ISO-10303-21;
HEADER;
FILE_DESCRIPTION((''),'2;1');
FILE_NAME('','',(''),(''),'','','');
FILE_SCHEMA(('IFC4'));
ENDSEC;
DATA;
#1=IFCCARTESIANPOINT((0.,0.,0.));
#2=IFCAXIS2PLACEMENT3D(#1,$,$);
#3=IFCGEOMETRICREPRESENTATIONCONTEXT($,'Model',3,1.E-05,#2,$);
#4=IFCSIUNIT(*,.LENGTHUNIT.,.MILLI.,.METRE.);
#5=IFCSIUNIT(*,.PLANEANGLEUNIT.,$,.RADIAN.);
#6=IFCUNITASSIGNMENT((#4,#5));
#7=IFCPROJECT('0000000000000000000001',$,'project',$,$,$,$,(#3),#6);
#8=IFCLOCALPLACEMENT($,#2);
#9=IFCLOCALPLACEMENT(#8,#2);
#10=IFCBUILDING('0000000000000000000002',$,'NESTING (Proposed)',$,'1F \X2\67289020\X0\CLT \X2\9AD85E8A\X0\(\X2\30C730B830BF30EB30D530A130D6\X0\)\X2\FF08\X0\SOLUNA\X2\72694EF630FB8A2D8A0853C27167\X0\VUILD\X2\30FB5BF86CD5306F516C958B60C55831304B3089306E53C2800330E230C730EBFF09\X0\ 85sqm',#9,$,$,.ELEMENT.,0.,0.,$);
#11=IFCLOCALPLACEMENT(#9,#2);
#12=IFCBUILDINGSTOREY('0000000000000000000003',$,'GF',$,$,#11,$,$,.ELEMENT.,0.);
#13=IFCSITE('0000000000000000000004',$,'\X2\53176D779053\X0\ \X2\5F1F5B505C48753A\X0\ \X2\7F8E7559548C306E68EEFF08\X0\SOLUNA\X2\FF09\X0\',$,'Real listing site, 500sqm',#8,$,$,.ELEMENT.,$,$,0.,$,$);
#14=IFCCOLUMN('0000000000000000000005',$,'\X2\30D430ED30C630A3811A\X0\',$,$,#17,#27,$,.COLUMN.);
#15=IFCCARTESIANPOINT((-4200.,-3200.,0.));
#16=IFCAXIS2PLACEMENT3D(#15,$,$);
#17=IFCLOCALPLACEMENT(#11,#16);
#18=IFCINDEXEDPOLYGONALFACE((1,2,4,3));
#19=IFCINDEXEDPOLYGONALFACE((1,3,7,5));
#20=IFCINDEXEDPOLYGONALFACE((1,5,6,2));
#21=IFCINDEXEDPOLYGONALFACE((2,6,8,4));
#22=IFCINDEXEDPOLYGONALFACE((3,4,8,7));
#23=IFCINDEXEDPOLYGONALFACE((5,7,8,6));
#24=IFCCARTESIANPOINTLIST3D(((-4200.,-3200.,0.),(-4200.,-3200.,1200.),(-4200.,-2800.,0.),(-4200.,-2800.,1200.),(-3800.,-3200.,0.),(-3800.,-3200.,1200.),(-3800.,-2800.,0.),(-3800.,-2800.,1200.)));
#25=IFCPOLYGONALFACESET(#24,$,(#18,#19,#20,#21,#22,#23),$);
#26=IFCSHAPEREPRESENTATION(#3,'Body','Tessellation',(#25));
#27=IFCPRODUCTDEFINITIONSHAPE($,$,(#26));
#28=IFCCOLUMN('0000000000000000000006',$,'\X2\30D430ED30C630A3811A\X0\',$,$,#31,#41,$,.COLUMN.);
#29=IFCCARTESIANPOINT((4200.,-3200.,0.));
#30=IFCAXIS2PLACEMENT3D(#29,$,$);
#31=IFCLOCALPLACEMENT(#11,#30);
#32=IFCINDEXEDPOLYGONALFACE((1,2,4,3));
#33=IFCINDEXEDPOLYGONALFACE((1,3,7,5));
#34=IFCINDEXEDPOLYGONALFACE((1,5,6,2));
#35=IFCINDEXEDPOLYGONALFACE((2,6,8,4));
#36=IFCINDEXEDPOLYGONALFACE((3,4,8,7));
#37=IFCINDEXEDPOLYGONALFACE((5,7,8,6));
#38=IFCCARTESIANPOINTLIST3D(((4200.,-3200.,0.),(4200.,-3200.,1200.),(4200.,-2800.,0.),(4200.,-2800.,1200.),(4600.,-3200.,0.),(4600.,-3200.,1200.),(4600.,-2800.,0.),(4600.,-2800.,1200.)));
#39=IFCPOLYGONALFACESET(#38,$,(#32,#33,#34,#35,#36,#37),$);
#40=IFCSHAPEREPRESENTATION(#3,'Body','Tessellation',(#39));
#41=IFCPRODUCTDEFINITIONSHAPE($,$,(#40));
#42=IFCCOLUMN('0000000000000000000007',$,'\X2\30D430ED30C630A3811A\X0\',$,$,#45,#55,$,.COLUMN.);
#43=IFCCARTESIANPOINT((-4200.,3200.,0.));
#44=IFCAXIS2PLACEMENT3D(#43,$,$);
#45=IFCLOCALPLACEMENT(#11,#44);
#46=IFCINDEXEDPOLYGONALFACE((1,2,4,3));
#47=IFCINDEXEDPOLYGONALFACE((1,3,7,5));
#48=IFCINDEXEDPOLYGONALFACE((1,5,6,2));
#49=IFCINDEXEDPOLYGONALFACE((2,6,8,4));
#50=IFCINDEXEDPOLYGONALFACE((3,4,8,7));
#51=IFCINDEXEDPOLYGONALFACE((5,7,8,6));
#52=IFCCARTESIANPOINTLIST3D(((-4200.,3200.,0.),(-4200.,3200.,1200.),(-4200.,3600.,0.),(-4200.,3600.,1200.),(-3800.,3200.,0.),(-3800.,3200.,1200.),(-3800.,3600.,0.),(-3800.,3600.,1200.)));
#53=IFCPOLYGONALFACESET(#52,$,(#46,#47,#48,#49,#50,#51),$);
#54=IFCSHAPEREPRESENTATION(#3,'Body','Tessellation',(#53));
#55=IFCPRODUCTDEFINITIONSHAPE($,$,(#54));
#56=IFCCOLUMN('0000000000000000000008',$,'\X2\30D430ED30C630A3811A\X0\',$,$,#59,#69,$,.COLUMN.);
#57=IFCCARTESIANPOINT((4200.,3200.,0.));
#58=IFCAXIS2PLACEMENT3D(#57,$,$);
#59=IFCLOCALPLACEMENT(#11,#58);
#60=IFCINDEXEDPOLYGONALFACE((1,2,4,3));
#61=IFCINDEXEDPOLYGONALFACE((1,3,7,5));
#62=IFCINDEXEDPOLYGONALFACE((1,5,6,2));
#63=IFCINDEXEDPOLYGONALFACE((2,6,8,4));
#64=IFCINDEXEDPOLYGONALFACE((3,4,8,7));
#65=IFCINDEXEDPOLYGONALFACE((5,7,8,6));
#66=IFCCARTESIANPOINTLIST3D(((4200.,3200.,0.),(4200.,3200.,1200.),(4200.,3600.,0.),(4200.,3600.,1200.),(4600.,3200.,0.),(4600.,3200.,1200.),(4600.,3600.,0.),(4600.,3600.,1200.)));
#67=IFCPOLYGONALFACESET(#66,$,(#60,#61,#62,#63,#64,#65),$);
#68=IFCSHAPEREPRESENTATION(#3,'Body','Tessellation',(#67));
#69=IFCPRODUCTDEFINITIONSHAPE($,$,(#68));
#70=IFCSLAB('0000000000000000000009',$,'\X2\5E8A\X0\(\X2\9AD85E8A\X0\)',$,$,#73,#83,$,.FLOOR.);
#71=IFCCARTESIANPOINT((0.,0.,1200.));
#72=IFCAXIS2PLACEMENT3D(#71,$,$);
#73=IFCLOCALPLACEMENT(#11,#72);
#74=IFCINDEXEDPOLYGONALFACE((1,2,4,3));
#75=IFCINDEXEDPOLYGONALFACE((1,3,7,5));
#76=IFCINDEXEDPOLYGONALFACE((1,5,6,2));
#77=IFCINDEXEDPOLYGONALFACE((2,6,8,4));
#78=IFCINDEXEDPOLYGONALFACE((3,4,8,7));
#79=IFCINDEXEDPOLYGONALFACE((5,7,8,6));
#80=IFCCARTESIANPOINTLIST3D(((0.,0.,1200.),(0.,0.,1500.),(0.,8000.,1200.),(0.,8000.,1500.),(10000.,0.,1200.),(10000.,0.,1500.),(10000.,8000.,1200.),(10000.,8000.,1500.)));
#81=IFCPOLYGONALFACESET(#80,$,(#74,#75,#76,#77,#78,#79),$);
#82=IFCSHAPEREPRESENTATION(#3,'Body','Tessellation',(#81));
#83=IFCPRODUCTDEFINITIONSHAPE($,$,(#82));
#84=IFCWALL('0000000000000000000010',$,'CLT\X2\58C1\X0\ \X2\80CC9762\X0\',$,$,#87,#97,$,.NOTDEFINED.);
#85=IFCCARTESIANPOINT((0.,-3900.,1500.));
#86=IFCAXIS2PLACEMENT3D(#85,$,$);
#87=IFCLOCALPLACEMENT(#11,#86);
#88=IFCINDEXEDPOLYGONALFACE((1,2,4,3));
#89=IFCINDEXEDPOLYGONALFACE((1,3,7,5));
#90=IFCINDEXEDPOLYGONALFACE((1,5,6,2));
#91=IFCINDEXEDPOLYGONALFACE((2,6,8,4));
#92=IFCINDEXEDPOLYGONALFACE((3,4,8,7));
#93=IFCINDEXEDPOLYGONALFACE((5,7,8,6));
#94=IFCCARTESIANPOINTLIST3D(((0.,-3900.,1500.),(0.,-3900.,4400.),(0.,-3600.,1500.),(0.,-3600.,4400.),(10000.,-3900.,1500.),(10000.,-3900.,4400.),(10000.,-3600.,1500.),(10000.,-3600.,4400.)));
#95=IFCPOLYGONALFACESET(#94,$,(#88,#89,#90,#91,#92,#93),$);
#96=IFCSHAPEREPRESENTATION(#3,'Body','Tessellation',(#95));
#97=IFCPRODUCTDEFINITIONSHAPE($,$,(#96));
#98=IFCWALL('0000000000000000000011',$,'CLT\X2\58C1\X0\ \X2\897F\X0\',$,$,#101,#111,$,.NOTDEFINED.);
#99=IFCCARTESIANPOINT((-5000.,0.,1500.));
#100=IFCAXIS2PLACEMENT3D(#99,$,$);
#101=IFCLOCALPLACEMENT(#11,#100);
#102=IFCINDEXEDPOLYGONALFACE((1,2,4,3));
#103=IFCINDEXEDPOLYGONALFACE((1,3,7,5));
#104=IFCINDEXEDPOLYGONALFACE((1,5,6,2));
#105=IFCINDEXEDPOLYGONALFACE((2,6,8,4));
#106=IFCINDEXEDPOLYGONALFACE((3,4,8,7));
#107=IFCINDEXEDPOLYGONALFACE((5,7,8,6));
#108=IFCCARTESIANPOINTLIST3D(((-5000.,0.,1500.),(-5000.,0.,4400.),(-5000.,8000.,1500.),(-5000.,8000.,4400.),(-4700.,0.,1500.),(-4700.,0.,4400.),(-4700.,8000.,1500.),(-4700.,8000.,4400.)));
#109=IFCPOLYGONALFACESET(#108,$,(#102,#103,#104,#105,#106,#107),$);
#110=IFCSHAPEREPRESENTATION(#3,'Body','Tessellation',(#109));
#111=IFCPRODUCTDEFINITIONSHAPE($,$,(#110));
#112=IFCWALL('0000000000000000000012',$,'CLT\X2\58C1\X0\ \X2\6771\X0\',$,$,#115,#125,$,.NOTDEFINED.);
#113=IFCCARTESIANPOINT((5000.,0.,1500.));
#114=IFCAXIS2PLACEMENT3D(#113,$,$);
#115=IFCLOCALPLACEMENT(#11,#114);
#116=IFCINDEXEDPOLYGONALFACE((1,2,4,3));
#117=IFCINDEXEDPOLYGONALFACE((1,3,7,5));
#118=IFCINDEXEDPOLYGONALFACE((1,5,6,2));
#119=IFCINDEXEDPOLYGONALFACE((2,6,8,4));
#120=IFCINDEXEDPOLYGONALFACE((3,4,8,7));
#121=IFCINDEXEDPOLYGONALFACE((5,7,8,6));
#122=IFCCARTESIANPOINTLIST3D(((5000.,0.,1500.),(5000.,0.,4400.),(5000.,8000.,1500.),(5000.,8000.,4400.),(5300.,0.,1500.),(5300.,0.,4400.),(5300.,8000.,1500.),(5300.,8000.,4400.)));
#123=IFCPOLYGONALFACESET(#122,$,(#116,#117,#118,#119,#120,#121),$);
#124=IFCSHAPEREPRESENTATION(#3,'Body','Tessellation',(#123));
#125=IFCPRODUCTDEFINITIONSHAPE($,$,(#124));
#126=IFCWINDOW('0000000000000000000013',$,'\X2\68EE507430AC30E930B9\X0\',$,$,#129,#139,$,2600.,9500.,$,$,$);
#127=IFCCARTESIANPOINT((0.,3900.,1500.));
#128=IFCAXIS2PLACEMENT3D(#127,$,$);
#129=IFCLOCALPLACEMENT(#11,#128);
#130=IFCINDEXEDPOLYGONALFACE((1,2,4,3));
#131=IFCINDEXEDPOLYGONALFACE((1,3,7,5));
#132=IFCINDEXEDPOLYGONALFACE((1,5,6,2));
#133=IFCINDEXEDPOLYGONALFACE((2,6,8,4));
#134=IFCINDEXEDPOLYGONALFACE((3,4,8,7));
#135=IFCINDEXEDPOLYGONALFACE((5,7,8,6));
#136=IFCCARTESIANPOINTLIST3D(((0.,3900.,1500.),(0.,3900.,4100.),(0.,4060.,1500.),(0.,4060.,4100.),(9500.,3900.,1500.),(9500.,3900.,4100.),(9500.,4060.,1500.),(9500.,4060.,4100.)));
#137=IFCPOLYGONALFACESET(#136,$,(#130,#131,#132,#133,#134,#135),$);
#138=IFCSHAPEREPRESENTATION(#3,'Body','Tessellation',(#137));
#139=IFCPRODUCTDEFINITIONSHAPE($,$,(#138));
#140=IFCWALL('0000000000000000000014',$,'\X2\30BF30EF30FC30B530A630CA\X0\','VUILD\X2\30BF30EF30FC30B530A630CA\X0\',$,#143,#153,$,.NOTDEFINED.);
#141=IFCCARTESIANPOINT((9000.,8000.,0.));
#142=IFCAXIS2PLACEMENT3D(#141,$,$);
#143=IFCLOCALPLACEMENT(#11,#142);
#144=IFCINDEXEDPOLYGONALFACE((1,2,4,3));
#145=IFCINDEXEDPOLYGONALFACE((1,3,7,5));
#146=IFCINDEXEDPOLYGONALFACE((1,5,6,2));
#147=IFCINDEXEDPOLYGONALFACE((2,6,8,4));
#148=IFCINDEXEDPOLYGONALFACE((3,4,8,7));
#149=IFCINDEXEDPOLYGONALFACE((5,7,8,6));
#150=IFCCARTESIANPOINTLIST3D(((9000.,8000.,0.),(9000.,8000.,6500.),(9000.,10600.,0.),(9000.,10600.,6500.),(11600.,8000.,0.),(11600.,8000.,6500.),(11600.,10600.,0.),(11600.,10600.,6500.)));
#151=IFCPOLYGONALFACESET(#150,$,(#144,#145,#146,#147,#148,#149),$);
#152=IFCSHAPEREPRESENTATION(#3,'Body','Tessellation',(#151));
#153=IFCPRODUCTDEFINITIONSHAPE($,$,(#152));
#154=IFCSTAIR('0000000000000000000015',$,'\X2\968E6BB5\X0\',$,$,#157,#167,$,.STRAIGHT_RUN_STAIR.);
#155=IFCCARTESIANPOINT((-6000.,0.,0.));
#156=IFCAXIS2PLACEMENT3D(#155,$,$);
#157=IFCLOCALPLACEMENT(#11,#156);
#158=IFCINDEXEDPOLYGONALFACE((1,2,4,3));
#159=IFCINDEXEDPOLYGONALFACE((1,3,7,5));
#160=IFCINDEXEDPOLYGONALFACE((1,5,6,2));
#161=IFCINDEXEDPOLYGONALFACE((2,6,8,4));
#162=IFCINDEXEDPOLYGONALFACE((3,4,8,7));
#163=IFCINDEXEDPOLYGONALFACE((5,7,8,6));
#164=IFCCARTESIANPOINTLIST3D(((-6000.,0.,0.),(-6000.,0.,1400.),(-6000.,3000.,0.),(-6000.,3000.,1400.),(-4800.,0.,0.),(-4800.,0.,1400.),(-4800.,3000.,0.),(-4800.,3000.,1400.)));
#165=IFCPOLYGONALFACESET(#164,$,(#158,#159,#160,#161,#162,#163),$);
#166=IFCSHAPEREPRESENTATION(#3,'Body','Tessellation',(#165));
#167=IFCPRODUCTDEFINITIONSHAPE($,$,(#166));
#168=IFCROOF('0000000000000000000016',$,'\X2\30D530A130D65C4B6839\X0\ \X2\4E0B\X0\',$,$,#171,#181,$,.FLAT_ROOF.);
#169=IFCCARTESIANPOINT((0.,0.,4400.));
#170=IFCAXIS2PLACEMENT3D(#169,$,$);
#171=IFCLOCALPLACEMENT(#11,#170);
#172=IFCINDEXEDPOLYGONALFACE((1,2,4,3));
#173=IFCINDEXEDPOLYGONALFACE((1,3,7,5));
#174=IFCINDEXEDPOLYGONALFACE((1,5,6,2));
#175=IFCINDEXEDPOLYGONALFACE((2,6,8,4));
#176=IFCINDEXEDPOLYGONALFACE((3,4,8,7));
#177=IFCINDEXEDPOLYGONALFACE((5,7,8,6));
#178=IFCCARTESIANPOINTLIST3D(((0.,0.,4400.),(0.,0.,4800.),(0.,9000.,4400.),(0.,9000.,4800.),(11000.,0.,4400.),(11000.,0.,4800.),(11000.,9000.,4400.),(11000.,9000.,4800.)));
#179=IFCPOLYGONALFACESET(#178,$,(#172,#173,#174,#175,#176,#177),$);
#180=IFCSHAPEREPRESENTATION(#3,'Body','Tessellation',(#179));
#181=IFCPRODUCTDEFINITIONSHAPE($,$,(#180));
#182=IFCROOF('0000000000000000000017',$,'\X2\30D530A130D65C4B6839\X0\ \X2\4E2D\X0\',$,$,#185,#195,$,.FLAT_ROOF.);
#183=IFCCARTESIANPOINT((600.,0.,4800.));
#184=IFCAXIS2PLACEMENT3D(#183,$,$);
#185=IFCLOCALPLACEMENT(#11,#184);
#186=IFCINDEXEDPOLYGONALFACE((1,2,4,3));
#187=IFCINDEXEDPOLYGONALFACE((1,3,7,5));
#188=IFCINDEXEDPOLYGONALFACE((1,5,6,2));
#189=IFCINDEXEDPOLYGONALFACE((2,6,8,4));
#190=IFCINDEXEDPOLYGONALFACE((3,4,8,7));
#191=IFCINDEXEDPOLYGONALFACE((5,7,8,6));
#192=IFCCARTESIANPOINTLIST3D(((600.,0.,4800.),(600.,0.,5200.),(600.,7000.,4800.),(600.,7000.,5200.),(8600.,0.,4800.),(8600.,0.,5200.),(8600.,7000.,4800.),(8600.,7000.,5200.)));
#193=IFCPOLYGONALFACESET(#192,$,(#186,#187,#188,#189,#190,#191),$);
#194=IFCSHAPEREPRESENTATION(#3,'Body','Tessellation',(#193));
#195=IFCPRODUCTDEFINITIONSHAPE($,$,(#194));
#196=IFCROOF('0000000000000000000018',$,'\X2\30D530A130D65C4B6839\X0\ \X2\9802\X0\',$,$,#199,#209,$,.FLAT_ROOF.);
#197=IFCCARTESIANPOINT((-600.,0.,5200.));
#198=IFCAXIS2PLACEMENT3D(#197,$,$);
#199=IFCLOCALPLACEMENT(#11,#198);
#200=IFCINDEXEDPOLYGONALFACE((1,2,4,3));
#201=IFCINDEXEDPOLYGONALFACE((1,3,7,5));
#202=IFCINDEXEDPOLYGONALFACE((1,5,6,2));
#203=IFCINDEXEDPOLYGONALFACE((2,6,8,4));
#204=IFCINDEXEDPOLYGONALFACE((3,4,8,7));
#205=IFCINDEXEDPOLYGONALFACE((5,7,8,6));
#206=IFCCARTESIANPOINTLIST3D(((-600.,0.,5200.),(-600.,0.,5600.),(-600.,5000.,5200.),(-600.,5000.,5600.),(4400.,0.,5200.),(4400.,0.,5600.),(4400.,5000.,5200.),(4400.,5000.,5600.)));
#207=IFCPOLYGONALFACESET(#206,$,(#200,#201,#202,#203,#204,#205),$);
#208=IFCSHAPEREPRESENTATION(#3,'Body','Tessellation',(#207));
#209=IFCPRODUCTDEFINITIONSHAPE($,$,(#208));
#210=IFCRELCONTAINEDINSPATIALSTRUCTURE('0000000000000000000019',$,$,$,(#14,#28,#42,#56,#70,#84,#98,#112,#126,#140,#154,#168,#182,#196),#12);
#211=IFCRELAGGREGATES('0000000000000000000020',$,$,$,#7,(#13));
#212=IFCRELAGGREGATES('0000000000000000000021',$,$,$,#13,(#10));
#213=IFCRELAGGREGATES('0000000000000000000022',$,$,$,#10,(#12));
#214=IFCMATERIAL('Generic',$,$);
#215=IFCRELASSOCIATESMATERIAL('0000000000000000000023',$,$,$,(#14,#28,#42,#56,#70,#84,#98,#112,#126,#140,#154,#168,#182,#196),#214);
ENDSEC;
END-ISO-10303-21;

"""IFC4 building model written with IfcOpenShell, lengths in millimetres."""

from ifc_helpers import new_model, si_unit, frame, frame_2d, origin, place, context, project, spatial, rectangle, extrude, material, element, fill, save


model = new_model("IFC4")

# Units and contexts
model_context = context("Model", 3, precision=1e-05, world=origin())
ifc_project = project(units=[si_unit("LENGTHUNIT", "METRE", prefix="MILLI"), si_unit("PLANEANGLEUNIT", "RADIAN")], contexts=[model_context])

# Site, building, storey
site_placement = place(None, origin())
site = spatial("IfcSite", under=ifc_project, at=site_placement, Name="北海道 弟子屈町 美留和の森（SOLUNA）", ObjectType="Real listing site, 500sqm", CompositionType="ELEMENT", RefElevation=0.0)
building_placement = place(site_placement, origin())
building = spatial("IfcBuilding", under=site, at=building_placement, Name="NESTING (Proposed)", ObjectType="1F 木造CLT 高床(デジタルファブ)（SOLUNA物件・設計参照VUILD・寸法は公開情報からの参考モデル） 85sqm", CompositionType="ELEMENT", ElevationOfRefHeight=0.0, ElevationOfTerrain=0.0)
storey_placement = place(building_placement, origin())
storey = spatial("IfcBuildingStorey", under=building, at=storey_placement, Name="GF", CompositionType="ELEMENT", Elevation=0.0)

# Columns
ifc_material_1 = material(Name="Generic")
column_1_placement = place(storey_placement, frame((-4200.0, -3200.0, 0.0)))
element("IfcColumn", 1, at=column_1_placement, inside=storey, material=ifc_material_1, Name="ピロティ脚", PredefinedType="COLUMN", context=model_context, shape_type="SweptSolid", body=[
    extrude(rectangle(XDim=400.0, YDim=400.0, at=frame_2d((200.0, 200.0))), frame((-4200.0, -3200.0, 0.0)), (0.0, 0.0, 1.0), 1200.0),
])
column_2_placement = place(storey_placement, frame((4200.0, -3200.0, 0.0)))
element("IfcColumn", 2, at=column_2_placement, inside=storey, material=ifc_material_1, Name="ピロティ脚", PredefinedType="COLUMN", context=model_context, shape_type="SweptSolid", body=[
    extrude(rectangle(XDim=400.0, YDim=400.0, at=frame_2d((200.0, 200.0))), frame((4200.0, -3200.0, 0.0)), (0.0, 0.0, 1.0), 1200.0),
])
column_3_placement = place(storey_placement, frame((-4200.0, 3200.0, 0.0)))
element("IfcColumn", 3, at=column_3_placement, inside=storey, material=ifc_material_1, Name="ピロティ脚", PredefinedType="COLUMN", context=model_context, shape_type="SweptSolid", body=[
    extrude(rectangle(XDim=400.0, YDim=400.0, at=frame_2d((200.0, 200.0))), frame((-4200.0, 3200.0, 0.0)), (0.0, 0.0, 1.0), 1200.0),
])
column_4_placement = place(storey_placement, frame((4200.0, 3200.0, 0.0)))
element("IfcColumn", 4, at=column_4_placement, inside=storey, material=ifc_material_1, Name="ピロティ脚", PredefinedType="COLUMN", context=model_context, shape_type="SweptSolid", body=[
    extrude(rectangle(XDim=400.0, YDim=400.0, at=frame_2d((200.0, 200.0))), frame((4200.0, 3200.0, 0.0)), (0.0, 0.0, 1.0), 1200.0),
])

# Slab
slab_placement = place(storey_placement, frame((0.0, 0.0, 1200.0)))
element("IfcSlab", 5, at=slab_placement, inside=storey, material=ifc_material_1, Name="床(高床)", PredefinedType="FLOOR", context=model_context, shape_type="SweptSolid", body=[
    extrude(rectangle(XDim=10000.0, YDim=8000.0, at=frame_2d((5000.0, 4000.0))), frame((0.0, 0.0, 1200.0)), (0.0, 0.0, 1.0), 300.0),
])

# Walls
wall_1_placement = place(storey_placement, frame((0.0, -3900.0, 1500.0)))
element("IfcWall", 6, at=wall_1_placement, inside=storey, material=ifc_material_1, Name="CLT壁 背面", PredefinedType="NOTDEFINED", context=model_context, shape_type="SweptSolid", body=[
    extrude(rectangle(XDim=10000.0, YDim=300.0, at=frame_2d((5000.0, 150.0))), frame((0.0, -3900.0, 1500.0)), (0.0, 0.0, 1.0), 2900.0),
])
wall_2_placement = place(storey_placement, frame((-5000.0, 0.0, 1500.0)))
element("IfcWall", 7, at=wall_2_placement, inside=storey, material=ifc_material_1, Name="CLT壁 西", PredefinedType="NOTDEFINED", context=model_context, shape_type="SweptSolid", body=[
    extrude(rectangle(XDim=300.0, YDim=8000.0, at=frame_2d((150.0, 4000.0))), frame((-5000.0, 0.0, 1500.0)), (0.0, 0.0, 1.0), 2900.0),
])

# Wall, opening, window
wall_3_placement = place(storey_placement, frame((5000.0, 0.0, 1500.0)))
wall_3 = element("IfcWall", 8, at=wall_3_placement, inside=storey, material=ifc_material_1, Name="CLT壁 東", PredefinedType="NOTDEFINED", context=model_context, shape_type="SweptSolid", body=[
    extrude(rectangle(XDim=300.0, YDim=8000.0, at=frame_2d((150.0, 4000.0))), frame((5000.0, 0.0, 1500.0)), (0.0, 0.0, 1.0), 2900.0),
])
opening_placement = place(storey_placement, frame((0.0, 3900.0, 1500.0)))
opening = element("IfcOpeningElement", 9, at=opening_placement, cuts=wall_3, PredefinedType="NOTDEFINED", context=model_context, shape_type="SweptSolid", body=[
    extrude(rectangle(XDim=9500.0, YDim=160.0, at=frame_2d((4750.0, 80.0))), frame((0.0, 3900.0, 1500.0)), (0.0, 0.0, 1.0), 2600.0),
])
window_placement = place(storey_placement, frame((0.0, 3900.0, 1500.0)))
window = element("IfcWindow", 10, at=window_placement, inside=storey, material=ifc_material_1, Name="森側ガラス", OverallHeight=2600.0, OverallWidth=9500.0, context=model_context, shape_type="SweptSolid", body=[
    extrude(rectangle(XDim=9500.0, YDim=160.0, at=frame_2d((4750.0, 80.0))), frame((0.0, 3900.0, 1500.0)), (0.0, 0.0, 1.0), 2600.0),
])
fill(opening, window)

# Wall
wall_4_placement = place(storey_placement, frame((9000.0, 8000.0, 0.0)))
element("IfcWall", 11, at=wall_4_placement, inside=storey, material=ifc_material_1, Name="タワーサウナ", Description="VUILDタワーサウナ", PredefinedType="NOTDEFINED", context=model_context, shape_type="SweptSolid", body=[
    extrude(rectangle(XDim=2600.0, YDim=2600.0, at=frame_2d((1300.0, 1300.0))), frame((9000.0, 8000.0, 0.0)), (0.0, 0.0, 1.0), 6500.0),
])

# Stair
stair_placement = place(storey_placement, frame((-6000.0, 0.0, 0.0)))
element("IfcStair", 12, at=stair_placement, inside=storey, material=ifc_material_1, Name="階段", PredefinedType="STRAIGHT_RUN_STAIR", context=model_context, shape_type="SweptSolid", body=[
    extrude(rectangle(XDim=1200.0, YDim=3000.0, at=frame_2d((600.0, 1500.0))), frame((-6000.0, 0.0, 0.0)), (0.0, 0.0, 1.0), 1400.0),
])

# Roofs
roof_1_placement = place(storey_placement, frame((0.0, 0.0, 4400.0)))
element("IfcRoof", 13, at=roof_1_placement, inside=storey, material=ifc_material_1, Name="ファブ屋根 下", PredefinedType="FLAT_ROOF", context=model_context, shape_type="SweptSolid", body=[
    extrude(rectangle(XDim=11000.0, YDim=9000.0, at=frame_2d((5500.0, 4500.0))), frame((0.0, 0.0, 4400.0)), (0.0, 0.0, 1.0), 400.0),
])
roof_2_placement = place(storey_placement, frame((600.0, 0.0, 4800.0)))
element("IfcRoof", 14, at=roof_2_placement, inside=storey, material=ifc_material_1, Name="ファブ屋根 中", PredefinedType="FLAT_ROOF", context=model_context, shape_type="SweptSolid", body=[
    extrude(rectangle(XDim=8000.0, YDim=7000.0, at=frame_2d((4000.0, 3500.0))), frame((600.0, 0.0, 4800.0)), (0.0, 0.0, 1.0), 400.0),
])
roof_3_placement = place(storey_placement, frame((-600.0, 0.0, 5200.0)))
element("IfcRoof", 15, at=roof_3_placement, inside=storey, material=ifc_material_1, Name="ファブ屋根 頂", PredefinedType="FLAT_ROOF", context=model_context, shape_type="SweptSolid", body=[
    extrude(rectangle(XDim=5000.0, YDim=5000.0, at=frame_2d((2500.0, 2500.0))), frame((-600.0, 0.0, 5200.0)), (0.0, 0.0, 1.0), 400.0),
])

save(model, "model.ifc")
